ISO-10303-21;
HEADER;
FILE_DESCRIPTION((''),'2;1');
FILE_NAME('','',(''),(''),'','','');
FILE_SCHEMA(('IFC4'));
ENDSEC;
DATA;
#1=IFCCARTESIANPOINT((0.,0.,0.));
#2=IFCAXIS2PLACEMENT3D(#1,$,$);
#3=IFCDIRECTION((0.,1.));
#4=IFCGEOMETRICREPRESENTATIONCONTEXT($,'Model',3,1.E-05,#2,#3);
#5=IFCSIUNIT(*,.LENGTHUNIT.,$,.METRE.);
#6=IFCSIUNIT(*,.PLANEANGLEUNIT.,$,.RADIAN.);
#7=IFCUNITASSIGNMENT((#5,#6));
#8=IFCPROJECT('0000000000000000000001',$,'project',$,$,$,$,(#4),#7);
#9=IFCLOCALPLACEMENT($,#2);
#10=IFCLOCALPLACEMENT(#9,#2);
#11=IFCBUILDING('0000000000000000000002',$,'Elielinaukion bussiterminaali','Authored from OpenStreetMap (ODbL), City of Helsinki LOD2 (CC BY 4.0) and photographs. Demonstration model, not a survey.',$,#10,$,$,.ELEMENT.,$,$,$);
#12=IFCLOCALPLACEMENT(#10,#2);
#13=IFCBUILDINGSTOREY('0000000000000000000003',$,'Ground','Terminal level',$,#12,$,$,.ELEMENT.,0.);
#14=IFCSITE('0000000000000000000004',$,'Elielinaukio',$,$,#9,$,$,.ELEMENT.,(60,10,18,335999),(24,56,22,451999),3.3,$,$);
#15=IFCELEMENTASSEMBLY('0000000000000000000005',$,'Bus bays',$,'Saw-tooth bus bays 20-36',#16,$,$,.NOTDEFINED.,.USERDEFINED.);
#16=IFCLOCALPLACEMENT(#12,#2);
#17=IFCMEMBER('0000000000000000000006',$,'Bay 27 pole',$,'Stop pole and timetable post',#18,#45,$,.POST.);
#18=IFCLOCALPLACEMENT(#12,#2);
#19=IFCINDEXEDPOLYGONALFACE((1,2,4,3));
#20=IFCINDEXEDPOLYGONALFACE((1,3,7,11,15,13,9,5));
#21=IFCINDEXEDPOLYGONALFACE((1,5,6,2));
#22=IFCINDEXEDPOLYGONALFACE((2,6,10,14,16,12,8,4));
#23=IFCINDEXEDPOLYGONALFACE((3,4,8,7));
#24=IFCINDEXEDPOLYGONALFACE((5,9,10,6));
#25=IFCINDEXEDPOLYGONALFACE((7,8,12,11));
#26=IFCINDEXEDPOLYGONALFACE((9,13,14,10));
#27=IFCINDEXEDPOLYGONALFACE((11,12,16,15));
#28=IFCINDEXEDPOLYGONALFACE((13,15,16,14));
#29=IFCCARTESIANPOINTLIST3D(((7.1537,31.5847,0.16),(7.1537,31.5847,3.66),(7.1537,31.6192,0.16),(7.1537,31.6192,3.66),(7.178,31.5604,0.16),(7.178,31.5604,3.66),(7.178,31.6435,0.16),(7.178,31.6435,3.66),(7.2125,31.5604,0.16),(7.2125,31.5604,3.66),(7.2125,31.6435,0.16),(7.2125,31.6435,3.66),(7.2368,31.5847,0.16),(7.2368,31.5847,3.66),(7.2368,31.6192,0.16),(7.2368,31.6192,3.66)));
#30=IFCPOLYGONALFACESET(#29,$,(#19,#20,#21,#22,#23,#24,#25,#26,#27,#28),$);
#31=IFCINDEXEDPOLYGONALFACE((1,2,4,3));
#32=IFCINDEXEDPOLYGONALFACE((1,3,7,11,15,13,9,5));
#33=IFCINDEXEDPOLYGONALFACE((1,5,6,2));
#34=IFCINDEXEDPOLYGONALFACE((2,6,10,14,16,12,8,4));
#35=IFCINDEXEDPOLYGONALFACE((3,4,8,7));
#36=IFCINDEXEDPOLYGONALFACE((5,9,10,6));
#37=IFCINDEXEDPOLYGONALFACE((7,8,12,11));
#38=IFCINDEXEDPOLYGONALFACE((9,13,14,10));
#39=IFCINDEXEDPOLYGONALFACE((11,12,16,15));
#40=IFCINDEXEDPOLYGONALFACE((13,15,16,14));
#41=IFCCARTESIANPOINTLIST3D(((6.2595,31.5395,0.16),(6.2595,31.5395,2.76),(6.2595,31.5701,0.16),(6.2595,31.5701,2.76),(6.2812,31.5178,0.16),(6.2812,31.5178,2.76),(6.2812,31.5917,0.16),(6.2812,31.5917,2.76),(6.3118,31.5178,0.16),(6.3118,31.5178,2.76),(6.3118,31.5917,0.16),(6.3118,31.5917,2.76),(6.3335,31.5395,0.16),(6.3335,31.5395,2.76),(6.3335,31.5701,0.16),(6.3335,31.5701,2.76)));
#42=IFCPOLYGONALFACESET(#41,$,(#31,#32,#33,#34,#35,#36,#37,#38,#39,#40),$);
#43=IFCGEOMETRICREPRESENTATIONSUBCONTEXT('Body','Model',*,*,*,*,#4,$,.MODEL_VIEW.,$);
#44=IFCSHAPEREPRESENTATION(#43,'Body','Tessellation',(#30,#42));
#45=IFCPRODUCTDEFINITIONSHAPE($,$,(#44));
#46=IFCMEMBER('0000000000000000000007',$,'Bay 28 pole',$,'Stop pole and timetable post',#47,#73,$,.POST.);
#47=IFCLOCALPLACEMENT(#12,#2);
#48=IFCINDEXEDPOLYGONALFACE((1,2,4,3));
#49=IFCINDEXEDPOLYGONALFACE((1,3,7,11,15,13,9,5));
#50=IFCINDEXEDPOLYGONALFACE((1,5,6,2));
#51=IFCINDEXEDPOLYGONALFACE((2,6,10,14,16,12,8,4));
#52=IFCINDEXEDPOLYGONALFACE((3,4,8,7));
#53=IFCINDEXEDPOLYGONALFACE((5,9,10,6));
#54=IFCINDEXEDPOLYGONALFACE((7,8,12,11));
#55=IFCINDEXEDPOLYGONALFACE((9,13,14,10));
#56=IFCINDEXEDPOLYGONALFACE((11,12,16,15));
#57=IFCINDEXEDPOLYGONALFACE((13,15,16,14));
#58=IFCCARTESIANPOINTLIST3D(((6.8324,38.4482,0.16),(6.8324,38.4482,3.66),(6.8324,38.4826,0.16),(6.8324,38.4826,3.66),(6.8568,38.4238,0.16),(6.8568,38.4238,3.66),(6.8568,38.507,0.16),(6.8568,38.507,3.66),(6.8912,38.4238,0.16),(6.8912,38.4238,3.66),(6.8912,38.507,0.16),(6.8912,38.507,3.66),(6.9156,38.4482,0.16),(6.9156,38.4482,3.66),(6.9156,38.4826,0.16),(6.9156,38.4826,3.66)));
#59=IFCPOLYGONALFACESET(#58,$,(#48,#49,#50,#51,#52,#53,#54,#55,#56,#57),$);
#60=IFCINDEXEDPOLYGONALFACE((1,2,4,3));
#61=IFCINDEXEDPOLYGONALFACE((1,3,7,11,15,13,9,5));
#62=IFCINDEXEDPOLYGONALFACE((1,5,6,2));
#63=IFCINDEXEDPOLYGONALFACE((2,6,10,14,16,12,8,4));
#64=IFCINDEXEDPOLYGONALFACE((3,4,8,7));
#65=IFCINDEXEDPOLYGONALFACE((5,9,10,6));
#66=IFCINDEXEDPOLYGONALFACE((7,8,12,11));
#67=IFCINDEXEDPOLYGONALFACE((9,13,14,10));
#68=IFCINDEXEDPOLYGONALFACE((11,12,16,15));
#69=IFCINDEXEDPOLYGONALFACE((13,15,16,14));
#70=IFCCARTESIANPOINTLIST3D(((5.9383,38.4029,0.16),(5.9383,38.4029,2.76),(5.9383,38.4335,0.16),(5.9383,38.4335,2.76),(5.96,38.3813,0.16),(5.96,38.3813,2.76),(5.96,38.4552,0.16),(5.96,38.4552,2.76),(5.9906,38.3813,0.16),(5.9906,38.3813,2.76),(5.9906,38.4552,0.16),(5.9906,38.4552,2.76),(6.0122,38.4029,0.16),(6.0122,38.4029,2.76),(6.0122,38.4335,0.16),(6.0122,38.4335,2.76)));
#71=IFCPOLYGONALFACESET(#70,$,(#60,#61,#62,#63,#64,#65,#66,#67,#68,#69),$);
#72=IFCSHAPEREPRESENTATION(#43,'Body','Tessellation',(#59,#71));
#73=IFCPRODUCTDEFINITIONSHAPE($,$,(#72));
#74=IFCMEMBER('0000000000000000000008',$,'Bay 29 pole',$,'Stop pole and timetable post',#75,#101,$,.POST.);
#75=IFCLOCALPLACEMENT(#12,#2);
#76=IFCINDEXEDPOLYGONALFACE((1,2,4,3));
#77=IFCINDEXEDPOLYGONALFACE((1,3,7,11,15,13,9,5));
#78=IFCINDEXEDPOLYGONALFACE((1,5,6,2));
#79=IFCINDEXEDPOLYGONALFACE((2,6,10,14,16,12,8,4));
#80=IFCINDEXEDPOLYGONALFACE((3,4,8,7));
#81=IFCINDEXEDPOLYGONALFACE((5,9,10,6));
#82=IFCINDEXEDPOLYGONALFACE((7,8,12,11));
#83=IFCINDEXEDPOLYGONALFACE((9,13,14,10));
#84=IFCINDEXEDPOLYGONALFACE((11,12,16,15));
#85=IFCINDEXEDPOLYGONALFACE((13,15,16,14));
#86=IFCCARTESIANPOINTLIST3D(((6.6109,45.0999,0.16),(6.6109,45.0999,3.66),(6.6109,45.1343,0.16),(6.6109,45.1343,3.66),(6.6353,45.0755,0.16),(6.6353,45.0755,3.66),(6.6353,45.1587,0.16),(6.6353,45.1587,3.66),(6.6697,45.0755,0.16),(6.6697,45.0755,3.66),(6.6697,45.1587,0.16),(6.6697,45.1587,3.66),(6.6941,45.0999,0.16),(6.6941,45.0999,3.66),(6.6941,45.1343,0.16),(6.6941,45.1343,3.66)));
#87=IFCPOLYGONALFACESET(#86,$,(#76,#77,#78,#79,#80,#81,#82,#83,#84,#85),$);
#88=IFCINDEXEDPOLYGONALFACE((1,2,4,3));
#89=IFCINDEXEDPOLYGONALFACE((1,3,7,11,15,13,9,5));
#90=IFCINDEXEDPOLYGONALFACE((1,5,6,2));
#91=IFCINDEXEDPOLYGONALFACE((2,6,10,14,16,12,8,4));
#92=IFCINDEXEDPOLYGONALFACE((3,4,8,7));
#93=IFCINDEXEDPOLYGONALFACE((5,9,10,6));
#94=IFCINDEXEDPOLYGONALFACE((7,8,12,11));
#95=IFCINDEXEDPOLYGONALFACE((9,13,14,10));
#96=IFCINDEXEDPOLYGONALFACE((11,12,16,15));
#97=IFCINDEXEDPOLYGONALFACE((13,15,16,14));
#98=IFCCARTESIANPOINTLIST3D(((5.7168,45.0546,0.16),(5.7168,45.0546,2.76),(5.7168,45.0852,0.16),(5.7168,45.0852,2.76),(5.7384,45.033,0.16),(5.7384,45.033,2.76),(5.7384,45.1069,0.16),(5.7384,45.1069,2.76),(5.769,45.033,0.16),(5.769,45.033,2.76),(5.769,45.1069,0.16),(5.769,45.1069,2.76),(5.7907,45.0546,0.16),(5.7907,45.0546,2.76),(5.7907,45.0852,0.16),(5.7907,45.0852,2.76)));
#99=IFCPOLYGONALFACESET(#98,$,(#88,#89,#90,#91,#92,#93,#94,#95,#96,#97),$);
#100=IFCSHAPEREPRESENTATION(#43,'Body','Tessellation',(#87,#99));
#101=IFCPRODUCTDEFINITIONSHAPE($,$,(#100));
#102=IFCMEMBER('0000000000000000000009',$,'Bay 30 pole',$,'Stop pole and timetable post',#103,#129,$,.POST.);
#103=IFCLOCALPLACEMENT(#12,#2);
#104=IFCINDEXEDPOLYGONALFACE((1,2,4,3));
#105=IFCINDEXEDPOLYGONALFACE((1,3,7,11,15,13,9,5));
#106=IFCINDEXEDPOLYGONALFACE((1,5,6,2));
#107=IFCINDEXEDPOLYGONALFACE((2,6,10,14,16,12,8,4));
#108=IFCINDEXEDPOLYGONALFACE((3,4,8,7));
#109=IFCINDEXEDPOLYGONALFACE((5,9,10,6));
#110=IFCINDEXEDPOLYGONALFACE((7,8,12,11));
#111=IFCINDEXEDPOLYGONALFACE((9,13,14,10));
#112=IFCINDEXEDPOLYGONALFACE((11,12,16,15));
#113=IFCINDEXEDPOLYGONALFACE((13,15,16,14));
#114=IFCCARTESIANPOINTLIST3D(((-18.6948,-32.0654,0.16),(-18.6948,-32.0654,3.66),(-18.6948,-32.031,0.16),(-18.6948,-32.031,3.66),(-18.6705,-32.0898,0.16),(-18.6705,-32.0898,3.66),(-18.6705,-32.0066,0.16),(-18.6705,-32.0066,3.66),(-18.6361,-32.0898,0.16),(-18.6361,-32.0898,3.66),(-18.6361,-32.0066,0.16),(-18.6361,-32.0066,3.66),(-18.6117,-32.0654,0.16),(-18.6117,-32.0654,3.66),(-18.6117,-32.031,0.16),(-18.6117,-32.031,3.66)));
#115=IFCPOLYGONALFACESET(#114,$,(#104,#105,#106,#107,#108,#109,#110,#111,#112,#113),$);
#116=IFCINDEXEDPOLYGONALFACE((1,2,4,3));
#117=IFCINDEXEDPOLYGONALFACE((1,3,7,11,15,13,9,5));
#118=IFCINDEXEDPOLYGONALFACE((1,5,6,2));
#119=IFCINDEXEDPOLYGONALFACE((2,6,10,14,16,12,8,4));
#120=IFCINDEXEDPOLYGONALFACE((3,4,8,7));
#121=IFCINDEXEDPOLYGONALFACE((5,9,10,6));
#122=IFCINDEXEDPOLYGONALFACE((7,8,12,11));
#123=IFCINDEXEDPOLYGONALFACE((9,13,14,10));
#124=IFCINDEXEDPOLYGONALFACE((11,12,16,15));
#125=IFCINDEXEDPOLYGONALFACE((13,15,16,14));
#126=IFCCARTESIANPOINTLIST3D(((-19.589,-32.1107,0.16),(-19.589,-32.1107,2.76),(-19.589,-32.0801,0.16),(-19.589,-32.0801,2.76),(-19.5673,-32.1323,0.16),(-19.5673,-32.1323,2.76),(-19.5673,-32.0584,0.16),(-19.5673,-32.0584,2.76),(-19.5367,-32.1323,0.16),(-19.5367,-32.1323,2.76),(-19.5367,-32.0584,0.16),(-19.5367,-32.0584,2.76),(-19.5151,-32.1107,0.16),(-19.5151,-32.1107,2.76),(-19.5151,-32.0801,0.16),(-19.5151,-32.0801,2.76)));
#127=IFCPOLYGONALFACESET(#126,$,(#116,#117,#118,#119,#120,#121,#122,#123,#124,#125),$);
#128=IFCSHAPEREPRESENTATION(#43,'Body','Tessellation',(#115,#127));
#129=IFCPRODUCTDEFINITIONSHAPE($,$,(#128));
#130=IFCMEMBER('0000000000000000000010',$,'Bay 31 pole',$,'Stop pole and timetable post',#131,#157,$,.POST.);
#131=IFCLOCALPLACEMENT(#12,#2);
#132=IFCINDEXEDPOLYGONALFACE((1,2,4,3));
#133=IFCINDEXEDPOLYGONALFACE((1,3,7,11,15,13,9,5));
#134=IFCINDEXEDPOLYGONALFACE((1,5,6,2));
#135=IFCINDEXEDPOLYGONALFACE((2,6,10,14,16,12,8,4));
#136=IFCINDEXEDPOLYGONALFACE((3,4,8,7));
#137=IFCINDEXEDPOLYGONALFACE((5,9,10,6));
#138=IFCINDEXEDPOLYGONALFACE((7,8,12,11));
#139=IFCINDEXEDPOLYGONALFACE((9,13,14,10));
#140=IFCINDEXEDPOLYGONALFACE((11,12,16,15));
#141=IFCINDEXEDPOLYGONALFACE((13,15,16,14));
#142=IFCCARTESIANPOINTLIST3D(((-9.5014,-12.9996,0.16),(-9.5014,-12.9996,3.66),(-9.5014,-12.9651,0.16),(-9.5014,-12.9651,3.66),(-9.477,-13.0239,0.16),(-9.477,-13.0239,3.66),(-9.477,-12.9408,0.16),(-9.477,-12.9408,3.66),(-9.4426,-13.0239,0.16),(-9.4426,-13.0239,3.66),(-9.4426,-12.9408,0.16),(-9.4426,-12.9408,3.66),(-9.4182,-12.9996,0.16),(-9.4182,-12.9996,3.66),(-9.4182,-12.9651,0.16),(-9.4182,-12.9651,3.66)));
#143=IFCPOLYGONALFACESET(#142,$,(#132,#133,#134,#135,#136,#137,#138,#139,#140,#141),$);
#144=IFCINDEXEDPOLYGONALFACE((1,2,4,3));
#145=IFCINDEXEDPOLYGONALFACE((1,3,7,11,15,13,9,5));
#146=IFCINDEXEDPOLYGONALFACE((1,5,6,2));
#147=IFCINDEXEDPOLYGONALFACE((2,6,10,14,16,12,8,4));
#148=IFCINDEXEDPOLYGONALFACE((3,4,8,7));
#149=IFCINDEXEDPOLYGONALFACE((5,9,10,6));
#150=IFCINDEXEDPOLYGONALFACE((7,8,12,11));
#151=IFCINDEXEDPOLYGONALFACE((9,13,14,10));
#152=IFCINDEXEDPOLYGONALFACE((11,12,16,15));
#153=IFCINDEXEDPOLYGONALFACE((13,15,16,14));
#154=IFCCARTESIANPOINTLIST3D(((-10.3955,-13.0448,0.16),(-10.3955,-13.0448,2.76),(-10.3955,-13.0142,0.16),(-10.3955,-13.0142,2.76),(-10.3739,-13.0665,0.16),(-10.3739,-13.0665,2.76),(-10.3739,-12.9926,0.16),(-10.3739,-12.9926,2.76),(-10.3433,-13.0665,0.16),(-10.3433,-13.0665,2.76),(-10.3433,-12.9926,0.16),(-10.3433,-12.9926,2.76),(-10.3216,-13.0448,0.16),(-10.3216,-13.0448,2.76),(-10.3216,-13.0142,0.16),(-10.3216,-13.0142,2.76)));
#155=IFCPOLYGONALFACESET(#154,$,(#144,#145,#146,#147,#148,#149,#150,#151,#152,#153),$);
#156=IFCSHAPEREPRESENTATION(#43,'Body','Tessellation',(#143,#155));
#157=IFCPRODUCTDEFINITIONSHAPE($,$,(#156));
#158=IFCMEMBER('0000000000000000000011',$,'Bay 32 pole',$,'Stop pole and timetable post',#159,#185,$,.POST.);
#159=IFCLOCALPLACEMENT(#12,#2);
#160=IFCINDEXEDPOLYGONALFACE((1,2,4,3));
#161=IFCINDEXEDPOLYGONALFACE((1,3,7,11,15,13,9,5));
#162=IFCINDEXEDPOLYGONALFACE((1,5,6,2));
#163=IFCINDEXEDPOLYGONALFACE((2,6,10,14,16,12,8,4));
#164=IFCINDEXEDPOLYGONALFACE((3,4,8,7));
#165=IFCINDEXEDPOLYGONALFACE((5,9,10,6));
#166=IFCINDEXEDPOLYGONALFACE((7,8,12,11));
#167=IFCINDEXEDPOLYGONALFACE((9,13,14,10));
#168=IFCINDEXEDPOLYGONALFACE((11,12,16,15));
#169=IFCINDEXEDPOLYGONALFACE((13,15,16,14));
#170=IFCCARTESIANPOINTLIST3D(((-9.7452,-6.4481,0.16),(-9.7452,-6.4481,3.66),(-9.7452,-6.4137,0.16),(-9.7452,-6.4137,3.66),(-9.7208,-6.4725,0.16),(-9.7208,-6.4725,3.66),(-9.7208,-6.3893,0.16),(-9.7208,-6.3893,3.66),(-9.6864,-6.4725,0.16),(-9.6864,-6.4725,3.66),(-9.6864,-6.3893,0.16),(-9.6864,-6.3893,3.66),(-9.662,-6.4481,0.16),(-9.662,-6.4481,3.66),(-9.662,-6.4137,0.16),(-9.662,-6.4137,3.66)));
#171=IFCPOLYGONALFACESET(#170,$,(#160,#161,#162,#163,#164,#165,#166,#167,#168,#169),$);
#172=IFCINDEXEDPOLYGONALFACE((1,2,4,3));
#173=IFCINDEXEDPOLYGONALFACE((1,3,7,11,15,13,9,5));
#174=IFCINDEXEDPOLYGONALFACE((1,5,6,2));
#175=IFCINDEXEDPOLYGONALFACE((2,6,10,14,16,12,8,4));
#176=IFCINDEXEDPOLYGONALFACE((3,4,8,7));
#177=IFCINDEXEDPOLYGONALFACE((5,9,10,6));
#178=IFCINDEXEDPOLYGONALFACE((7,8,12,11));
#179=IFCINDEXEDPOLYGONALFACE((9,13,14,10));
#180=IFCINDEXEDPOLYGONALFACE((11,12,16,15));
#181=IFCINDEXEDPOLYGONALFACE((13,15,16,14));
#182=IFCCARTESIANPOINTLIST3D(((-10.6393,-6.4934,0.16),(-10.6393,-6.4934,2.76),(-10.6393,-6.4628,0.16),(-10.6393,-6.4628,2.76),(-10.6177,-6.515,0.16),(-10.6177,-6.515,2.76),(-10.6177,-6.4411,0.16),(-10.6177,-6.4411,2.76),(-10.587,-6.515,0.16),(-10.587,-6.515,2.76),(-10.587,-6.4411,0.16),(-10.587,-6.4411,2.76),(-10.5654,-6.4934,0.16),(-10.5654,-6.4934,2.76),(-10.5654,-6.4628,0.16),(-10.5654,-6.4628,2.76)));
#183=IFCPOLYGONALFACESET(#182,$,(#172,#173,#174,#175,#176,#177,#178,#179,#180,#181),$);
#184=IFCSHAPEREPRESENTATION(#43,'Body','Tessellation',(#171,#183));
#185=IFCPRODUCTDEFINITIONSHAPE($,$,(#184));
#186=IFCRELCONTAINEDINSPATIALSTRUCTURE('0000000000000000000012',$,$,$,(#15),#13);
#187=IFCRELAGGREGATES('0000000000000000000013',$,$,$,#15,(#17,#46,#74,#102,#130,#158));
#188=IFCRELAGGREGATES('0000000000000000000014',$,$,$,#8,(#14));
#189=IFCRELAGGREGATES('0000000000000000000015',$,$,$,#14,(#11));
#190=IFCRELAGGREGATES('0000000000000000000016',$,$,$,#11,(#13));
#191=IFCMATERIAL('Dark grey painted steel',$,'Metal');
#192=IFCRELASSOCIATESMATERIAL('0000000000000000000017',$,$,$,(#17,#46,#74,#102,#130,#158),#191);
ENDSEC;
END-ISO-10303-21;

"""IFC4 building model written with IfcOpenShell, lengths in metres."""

from ifc_helpers import new_model, si_unit, direction, frame, origin, place, context, subcontext, project, spatial, polyline, outline, extrude, material, element, aggregate, save


model = new_model("IFC4")

# Units and contexts
model_context = context("Model", 3, precision=1e-05, world=origin(), true_north=direction((0.0, 1.0)))
body_context = subcontext(model_context, "Body", "Model", "MODEL_VIEW")
ifc_project = project(units=[si_unit("LENGTHUNIT", "METRE"), si_unit("PLANEANGLEUNIT", "RADIAN")], contexts=[model_context])

# Site, building, storey
site_placement = place(None, origin())
site = spatial("IfcSite", under=ifc_project, at=site_placement, Name="Elielinaukio", CompositionType="ELEMENT", RefLatitude=(60, 10, 18, 335999), RefLongitude=(24, 56, 22, 451999), RefElevation=3.3)
building_placement = place(site_placement, origin())
building = spatial("IfcBuilding", under=site, at=building_placement, Name="Elielinaukion bussiterminaali", Description="Authored from OpenStreetMap (ODbL), City of Helsinki LOD2 (CC BY 4.0) and photographs. Demonstration model, not a survey.", CompositionType="ELEMENT")
storey_placement = place(building_placement, origin())
storey = spatial("IfcBuildingStorey", under=building, at=storey_placement, Name="Ground", Description="Terminal level", CompositionType="ELEMENT", Elevation=0.0)

# Element assembly, members
assembly_placement = place(building_placement, origin())
assembly = element("IfcElementAssembly", 1, at=assembly_placement, inside=storey, Name="Bus bays", ObjectType="Saw-tooth bus bays 20-36", AssemblyPlace="NOTDEFINED", PredefinedType="USERDEFINED")
ifc_material_1 = material(Name="Dark grey painted steel", Category="Metal")
member_1_placement = place(building_placement, origin())
member_1 = element("IfcMember", 2, at=member_1_placement, material=ifc_material_1, Name="Bay 27 pole", ObjectType="Stop pole and timetable post", PredefinedType="POST", context=body_context, shape_type="SweptSolid", body=[
    extrude(outline(polyline([(7.2368, 31.6192), (7.2125, 31.6435), (7.178, 31.6435), (7.1537, 31.6192), (7.1537, 31.5847), (7.178, 31.5604), (7.2125, 31.5604), (7.2368, 31.5847), (7.2368, 31.6192)])), frame((0.0, 0.0, 0.16)), (0.0, 0.0, 1.0), 3.5),
    extrude(outline(polyline([(6.3335, 31.5701), (6.3118, 31.5917), (6.2812, 31.5917), (6.2595, 31.5701), (6.2595, 31.5395), (6.2812, 31.5178), (6.3118, 31.5178), (6.3335, 31.5395), (6.3335, 31.5701)])), frame((0.0, 0.0, 0.16)), (0.0, 0.0, 1.0), 2.6),
])
member_2_placement = place(building_placement, origin())
member_2 = element("IfcMember", 3, at=member_2_placement, material=ifc_material_1, Name="Bay 28 pole", ObjectType="Stop pole and timetable post", PredefinedType="POST", context=body_context, shape_type="SweptSolid", body=[
    extrude(outline(polyline([(6.9156, 38.4826), (6.8912, 38.507), (6.8568, 38.507), (6.8324, 38.4826), (6.8324, 38.4482), (6.8568, 38.4238), (6.8912, 38.4238), (6.9156, 38.4482), (6.9156, 38.4826)])), frame((0.0, 0.0, 0.16)), (0.0, 0.0, 1.0), 3.5),
    extrude(outline(polyline([(6.0122, 38.4335), (5.9906, 38.4552), (5.96, 38.4552), (5.9383, 38.4335), (5.9383, 38.4029), (5.96, 38.3813), (5.9906, 38.3813), (6.0122, 38.4029), (6.0122, 38.4335)])), frame((0.0, 0.0, 0.16)), (0.0, 0.0, 1.0), 2.6),
])
member_3_placement = place(building_placement, origin())
member_3 = element("IfcMember", 4, at=member_3_placement, material=ifc_material_1, Name="Bay 29 pole", ObjectType="Stop pole and timetable post", PredefinedType="POST", context=body_context, shape_type="SweptSolid", body=[
    extrude(outline(polyline([(6.6941, 45.1343), (6.6697, 45.1587), (6.6353, 45.1587), (6.6109, 45.1343), (6.6109, 45.0999), (6.6353, 45.0755), (6.6697, 45.0755), (6.6941, 45.0999), (6.6941, 45.1343)])), frame((0.0, 0.0, 0.16)), (0.0, 0.0, 1.0), 3.5),
    extrude(outline(polyline([(5.7907, 45.0852), (5.769, 45.1069), (5.7384, 45.1069), (5.7168, 45.0852), (5.7168, 45.0546), (5.7384, 45.033), (5.769, 45.033), (5.7907, 45.0546), (5.7907, 45.0852)])), frame((0.0, 0.0, 0.16)), (0.0, 0.0, 1.0), 2.6),
])
member_4_placement = place(building_placement, origin())
member_4 = element("IfcMember", 5, at=member_4_placement, material=ifc_material_1, Name="Bay 30 pole", ObjectType="Stop pole and timetable post", PredefinedType="POST", context=body_context, shape_type="SweptSolid", body=[
    extrude(outline(polyline([(-18.6117, -32.031), (-18.6361, -32.0066), (-18.6705, -32.0066), (-18.6948, -32.031), (-18.6948, -32.0654), (-18.6705, -32.0898), (-18.6361, -32.0898), (-18.6117, -32.0654), (-18.6117, -32.031)])), frame((0.0, 0.0, 0.16)), (0.0, 0.0, 1.0), 3.5),
    extrude(outline(polyline([(-19.5151, -32.0801), (-19.5367, -32.0584), (-19.5673, -32.0584), (-19.589, -32.0801), (-19.589, -32.1107), (-19.5673, -32.1323), (-19.5367, -32.1323), (-19.5151, -32.1107), (-19.5151, -32.0801)])), frame((0.0, 0.0, 0.16)), (0.0, 0.0, 1.0), 2.6),
])
member_5_placement = place(building_placement, origin())
member_5 = element("IfcMember", 6, at=member_5_placement, material=ifc_material_1, Name="Bay 31 pole", ObjectType="Stop pole and timetable post", PredefinedType="POST", context=body_context, shape_type="SweptSolid", body=[
    extrude(outline(polyline([(-9.4182, -12.9651), (-9.4426, -12.9408), (-9.477, -12.9408), (-9.5014, -12.9651), (-9.5014, -12.9996), (-9.477, -13.0239), (-9.4426, -13.0239), (-9.4182, -12.9996), (-9.4182, -12.9651)])), frame((0.0, 0.0, 0.16)), (0.0, 0.0, 1.0), 3.5),
    extrude(outline(polyline([(-10.3216, -13.0142), (-10.3433, -12.9926), (-10.3739, -12.9926), (-10.3955, -13.0142), (-10.3955, -13.0448), (-10.3739, -13.0665), (-10.3433, -13.0665), (-10.3216, -13.0448), (-10.3216, -13.0142)])), frame((0.0, 0.0, 0.16)), (0.0, 0.0, 1.0), 2.6),
])
member_6_placement = place(building_placement, origin())
member_6 = element("IfcMember", 7, at=member_6_placement, material=ifc_material_1, Name="Bay 32 pole", ObjectType="Stop pole and timetable post", PredefinedType="POST", context=body_context, shape_type="SweptSolid", body=[
    extrude(outline(polyline([(-9.662, -6.4137), (-9.6864, -6.3893), (-9.7208, -6.3893), (-9.7452, -6.4137), (-9.7452, -6.4481), (-9.7208, -6.4725), (-9.6864, -6.4725), (-9.662, -6.4481), (-9.662, -6.4137)])), frame((0.0, 0.0, 0.16)), (0.0, 0.0, 1.0), 3.5),
    extrude(outline(polyline([(-10.5654, -6.4628), (-10.587, -6.4411), (-10.6177, -6.4411), (-10.6393, -6.4628), (-10.6393, -6.4934), (-10.6177, -6.515), (-10.587, -6.515), (-10.5654, -6.4934), (-10.5654, -6.4628)])), frame((0.0, 0.0, 0.16)), (0.0, 0.0, 1.0), 2.6),
])
aggregate(assembly, [member_1, member_2, member_3, member_4, member_5, member_6])

save(model, "model.ifc")
